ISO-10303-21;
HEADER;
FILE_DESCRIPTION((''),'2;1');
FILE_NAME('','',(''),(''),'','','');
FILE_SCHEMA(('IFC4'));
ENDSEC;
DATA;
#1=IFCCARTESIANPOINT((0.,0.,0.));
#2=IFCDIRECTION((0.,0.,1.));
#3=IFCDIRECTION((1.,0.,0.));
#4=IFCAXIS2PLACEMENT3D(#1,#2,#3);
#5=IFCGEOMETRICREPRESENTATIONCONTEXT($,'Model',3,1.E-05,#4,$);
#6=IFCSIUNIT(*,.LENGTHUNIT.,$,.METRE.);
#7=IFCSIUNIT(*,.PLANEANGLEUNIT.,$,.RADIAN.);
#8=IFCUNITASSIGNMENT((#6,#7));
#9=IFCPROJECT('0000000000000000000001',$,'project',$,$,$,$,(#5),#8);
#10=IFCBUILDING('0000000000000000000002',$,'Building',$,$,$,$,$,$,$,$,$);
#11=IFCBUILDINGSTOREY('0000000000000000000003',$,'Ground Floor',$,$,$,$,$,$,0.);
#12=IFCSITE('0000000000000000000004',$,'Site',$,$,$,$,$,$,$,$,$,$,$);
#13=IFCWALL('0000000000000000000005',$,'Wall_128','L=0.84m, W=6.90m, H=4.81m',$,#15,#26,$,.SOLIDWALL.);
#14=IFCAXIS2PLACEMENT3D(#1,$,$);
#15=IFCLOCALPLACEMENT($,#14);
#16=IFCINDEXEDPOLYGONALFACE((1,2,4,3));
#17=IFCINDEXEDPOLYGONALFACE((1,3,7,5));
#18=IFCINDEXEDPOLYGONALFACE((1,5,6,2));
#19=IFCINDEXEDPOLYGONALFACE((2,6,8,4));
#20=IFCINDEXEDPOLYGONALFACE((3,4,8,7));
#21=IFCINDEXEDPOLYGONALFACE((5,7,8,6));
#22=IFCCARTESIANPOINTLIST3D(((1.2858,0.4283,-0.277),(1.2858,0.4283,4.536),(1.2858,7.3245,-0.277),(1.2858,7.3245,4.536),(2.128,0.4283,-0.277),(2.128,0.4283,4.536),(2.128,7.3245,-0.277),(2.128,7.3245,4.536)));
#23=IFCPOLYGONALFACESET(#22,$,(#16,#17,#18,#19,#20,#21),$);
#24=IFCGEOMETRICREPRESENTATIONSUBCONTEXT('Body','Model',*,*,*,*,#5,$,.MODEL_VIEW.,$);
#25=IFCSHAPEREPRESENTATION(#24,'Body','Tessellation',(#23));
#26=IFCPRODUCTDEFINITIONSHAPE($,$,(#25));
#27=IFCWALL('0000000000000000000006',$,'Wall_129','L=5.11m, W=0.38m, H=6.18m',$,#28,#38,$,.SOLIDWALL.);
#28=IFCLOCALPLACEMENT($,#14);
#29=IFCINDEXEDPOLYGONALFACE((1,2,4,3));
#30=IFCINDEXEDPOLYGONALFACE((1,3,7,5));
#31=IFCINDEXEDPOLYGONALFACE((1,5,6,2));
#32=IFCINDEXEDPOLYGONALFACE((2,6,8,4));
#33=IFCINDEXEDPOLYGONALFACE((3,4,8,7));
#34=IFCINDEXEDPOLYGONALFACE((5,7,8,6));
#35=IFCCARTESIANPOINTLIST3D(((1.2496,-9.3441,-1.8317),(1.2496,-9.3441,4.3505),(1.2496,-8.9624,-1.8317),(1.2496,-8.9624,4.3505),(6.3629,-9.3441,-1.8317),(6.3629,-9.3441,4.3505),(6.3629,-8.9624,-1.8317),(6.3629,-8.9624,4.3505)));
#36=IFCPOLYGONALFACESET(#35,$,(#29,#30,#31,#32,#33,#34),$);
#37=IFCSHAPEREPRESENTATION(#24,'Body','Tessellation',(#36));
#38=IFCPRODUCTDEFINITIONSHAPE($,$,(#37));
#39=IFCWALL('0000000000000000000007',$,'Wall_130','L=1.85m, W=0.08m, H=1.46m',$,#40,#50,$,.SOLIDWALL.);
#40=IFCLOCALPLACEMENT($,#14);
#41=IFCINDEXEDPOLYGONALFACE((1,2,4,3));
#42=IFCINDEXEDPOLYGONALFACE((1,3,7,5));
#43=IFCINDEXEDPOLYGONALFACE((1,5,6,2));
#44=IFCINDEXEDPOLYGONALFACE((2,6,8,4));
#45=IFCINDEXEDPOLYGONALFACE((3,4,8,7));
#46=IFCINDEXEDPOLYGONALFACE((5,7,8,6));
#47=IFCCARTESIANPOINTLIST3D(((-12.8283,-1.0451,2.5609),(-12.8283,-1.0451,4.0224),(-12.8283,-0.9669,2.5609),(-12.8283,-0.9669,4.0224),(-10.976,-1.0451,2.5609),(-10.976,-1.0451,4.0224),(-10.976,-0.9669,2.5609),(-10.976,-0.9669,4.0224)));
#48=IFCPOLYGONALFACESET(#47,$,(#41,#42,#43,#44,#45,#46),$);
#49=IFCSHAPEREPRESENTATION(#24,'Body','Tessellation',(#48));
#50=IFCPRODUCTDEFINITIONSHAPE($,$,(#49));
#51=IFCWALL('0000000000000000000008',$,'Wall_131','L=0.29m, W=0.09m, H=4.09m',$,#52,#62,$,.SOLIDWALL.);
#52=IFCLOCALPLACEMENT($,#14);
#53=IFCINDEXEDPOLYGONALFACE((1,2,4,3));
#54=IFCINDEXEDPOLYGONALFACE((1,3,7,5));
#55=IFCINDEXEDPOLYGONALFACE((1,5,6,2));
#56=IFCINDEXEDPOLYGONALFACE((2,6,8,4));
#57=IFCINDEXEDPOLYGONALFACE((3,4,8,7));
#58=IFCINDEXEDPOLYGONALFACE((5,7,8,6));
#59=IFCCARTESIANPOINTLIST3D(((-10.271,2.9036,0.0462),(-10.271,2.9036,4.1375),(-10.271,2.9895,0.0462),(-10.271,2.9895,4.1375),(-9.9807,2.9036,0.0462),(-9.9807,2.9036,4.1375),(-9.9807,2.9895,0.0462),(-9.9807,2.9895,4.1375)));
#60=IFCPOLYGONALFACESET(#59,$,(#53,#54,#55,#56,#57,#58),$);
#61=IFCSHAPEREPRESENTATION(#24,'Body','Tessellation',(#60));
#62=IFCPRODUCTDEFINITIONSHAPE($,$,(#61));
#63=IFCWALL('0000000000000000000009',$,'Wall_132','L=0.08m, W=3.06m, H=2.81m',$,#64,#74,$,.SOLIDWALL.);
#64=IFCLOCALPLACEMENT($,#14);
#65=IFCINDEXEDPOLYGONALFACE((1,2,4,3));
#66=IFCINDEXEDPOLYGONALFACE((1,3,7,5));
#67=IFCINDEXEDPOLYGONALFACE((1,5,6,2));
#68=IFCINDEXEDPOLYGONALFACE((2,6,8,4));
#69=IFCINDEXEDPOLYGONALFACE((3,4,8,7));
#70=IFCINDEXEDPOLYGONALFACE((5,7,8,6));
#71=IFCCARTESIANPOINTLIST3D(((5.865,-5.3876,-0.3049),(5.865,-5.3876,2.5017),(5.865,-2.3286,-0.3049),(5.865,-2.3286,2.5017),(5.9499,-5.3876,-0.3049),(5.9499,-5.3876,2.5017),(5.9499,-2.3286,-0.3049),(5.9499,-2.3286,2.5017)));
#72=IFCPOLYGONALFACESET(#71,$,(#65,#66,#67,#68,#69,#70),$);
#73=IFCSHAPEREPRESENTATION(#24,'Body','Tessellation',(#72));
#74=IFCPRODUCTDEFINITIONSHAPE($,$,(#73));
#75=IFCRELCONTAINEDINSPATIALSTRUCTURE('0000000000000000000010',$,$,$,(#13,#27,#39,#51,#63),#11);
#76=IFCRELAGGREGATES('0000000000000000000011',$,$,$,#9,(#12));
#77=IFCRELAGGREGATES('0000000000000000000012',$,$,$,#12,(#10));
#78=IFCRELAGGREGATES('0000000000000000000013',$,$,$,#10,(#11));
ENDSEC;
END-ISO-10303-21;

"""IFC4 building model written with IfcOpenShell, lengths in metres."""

from ifc_helpers import new_model, si_unit, frame, origin_with_axes, origin_2d, context, subcontext, project, spatial, rectangle, extrude, element, save


model = new_model("IFC4")

# Units and contexts
model_context = context("Model", 3, precision=1e-05, world=origin_with_axes())
body_context = subcontext(model_context, "Body", "Model", "MODEL_VIEW")
ifc_project = project(units=[si_unit("LENGTHUNIT", "METRE"), si_unit("PLANEANGLEUNIT", "RADIAN")], contexts=[model_context])

# Site, building, storey
site = spatial("IfcSite", under=ifc_project, Name="Site")
building = spatial("IfcBuilding", under=site, Name="Building")
storey = spatial("IfcBuildingStorey", under=building, Name="Ground Floor", Elevation=0.0)

# Walls
element("IfcWall", 1, inside=storey, Name="Wall_128", Description="L=0.84m, W=6.90m, H=4.81m", PredefinedType="SOLIDWALL", context=body_context, shape_type="SweptSolid", body=[
    extrude(rectangle(XDim=0.8422, YDim=6.8962, at=origin_2d()), frame((1.7069, 3.8764, -0.277), z_axis=(0.0, 0.0, 1.0), x_axis=(1.0, 0.0, 0.0)), (0.0, 0.0, 1.0), 4.8129),
])
element("IfcWall", 2, inside=storey, Name="Wall_129", Description="L=5.11m, W=0.38m, H=6.18m", PredefinedType="SOLIDWALL", context=body_context, shape_type="SweptSolid", body=[
    extrude(rectangle(XDim=5.1133, YDim=0.3817, at=origin_2d()), frame((3.8063, -9.1532, -1.8317), z_axis=(0.0, 0.0, 1.0), x_axis=(1.0, 0.0, 0.0)), (0.0, 0.0, 1.0), 6.1822),
])
element("IfcWall", 3, inside=storey, Name="Wall_130", Description="L=1.85m, W=0.08m, H=1.46m", PredefinedType="SOLIDWALL", context=body_context, shape_type="SweptSolid", body=[
    extrude(rectangle(XDim=1.8523, YDim=0.0783, at=origin_2d()), frame((-11.9021, -1.006, 2.5609), z_axis=(0.0, 0.0, 1.0), x_axis=(1.0, 0.0, 0.0)), (0.0, 0.0, 1.0), 1.4615),
])
element("IfcWall", 4, inside=storey, Name="Wall_131", Description="L=0.29m, W=0.09m, H=4.09m", PredefinedType="SOLIDWALL", context=body_context, shape_type="SweptSolid", body=[
    extrude(rectangle(XDim=0.2903, YDim=0.0859, at=origin_2d()), frame((-10.1258, 2.9466, 0.0462), z_axis=(0.0, 0.0, 1.0), x_axis=(1.0, 0.0, 0.0)), (0.0, 0.0, 1.0), 4.0912),
])
element("IfcWall", 5, inside=storey, Name="Wall_132", Description="L=0.08m, W=3.06m, H=2.81m", PredefinedType="SOLIDWALL", context=body_context, shape_type="SweptSolid", body=[
    extrude(rectangle(XDim=0.0849, YDim=3.059, at=origin_2d()), frame((5.9074, -3.8581, -0.3049), z_axis=(0.0, 0.0, 1.0), x_axis=(1.0, 0.0, 0.0)), (0.0, 0.0, 1.0), 2.8066),
])

save(model, "model.ifc")
